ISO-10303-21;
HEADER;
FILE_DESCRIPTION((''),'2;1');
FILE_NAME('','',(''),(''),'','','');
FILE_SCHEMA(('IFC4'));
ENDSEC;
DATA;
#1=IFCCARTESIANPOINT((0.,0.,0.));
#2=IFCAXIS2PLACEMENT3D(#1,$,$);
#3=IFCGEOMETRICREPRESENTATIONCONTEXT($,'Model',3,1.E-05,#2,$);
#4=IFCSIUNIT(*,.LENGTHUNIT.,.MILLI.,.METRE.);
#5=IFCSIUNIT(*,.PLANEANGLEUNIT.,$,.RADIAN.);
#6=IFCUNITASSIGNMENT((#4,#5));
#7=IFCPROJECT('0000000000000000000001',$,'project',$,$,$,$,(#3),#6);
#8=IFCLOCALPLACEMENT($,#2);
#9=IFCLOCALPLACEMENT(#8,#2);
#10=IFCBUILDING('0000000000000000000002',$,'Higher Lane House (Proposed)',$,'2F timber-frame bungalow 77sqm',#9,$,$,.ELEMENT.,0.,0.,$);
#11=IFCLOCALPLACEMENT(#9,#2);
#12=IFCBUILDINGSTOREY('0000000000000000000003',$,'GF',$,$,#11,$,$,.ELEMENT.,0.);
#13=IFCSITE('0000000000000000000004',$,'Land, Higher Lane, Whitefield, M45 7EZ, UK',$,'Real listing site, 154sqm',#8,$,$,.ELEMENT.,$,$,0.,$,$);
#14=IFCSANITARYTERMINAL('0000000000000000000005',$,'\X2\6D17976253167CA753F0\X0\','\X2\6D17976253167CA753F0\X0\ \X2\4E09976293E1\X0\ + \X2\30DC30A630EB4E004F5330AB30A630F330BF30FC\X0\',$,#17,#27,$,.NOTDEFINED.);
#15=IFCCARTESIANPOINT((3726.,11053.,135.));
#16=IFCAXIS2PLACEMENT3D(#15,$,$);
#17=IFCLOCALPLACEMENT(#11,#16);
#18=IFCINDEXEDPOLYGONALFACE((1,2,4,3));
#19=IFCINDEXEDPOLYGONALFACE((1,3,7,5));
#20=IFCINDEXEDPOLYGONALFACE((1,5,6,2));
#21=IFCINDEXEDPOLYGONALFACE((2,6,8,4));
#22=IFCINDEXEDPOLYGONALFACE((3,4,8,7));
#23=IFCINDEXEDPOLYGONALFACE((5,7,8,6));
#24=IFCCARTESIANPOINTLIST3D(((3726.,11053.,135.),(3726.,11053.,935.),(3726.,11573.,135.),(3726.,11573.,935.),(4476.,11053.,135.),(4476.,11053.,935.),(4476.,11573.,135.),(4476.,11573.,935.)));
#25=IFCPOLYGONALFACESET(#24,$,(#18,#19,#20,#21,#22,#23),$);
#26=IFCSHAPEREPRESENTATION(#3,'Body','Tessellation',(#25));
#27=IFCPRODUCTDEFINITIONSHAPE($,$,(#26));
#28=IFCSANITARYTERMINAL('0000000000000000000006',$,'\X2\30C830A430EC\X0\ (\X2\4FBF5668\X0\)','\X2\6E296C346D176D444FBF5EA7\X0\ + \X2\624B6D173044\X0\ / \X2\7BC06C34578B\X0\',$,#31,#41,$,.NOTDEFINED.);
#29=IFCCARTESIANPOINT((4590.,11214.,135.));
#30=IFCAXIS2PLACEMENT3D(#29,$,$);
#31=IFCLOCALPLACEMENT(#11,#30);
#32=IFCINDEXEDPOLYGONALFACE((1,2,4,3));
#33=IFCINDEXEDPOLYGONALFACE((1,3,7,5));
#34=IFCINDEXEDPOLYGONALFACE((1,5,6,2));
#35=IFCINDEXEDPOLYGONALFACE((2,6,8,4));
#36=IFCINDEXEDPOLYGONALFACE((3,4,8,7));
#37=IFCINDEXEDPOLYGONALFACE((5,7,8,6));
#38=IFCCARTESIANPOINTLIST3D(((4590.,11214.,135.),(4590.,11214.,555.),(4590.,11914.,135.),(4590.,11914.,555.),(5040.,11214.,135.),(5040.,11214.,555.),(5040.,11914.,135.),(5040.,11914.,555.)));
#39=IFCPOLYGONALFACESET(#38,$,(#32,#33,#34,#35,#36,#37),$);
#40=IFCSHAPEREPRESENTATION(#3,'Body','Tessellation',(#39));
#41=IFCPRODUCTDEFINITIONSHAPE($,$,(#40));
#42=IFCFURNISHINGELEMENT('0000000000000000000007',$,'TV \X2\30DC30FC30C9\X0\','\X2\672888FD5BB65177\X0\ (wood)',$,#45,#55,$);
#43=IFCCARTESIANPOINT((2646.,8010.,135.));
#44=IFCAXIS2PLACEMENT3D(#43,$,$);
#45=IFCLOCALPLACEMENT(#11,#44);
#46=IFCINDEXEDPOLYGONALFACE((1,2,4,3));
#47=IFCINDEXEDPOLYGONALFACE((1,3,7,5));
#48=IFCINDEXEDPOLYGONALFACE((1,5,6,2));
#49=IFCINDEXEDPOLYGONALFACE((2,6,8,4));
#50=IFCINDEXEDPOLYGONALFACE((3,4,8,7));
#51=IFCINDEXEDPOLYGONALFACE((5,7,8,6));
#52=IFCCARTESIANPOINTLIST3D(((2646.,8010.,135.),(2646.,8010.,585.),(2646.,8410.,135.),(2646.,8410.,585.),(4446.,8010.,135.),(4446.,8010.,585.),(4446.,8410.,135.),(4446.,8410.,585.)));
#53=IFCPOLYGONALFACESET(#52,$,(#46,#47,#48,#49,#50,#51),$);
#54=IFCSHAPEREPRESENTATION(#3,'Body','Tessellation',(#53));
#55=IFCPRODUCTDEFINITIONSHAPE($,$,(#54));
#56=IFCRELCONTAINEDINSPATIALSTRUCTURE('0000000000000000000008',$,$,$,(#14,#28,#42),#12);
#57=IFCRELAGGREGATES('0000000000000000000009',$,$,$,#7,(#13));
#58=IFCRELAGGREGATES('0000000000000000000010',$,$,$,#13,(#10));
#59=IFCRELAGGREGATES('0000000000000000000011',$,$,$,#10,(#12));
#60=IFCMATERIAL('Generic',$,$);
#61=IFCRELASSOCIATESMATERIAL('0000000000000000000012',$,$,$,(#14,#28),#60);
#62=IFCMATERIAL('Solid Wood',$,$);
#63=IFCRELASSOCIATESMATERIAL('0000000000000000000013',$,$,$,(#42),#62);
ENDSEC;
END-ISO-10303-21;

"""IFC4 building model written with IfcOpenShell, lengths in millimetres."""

from ifc_helpers import new_model, si_unit, frame, frame_2d, origin, place, context, project, spatial, rectangle, extrude, material, element, save


model = new_model("IFC4")

# Units and contexts
model_context = context("Model", 3, precision=1e-05, world=origin())
ifc_project = project(units=[si_unit("LENGTHUNIT", "METRE", prefix="MILLI"), si_unit("PLANEANGLEUNIT", "RADIAN")], contexts=[model_context])

# Site, building, storey
site_placement = place(None, origin())
site = spatial("IfcSite", under=ifc_project, at=site_placement, Name="Land, Higher Lane, Whitefield, M45 7EZ, UK", ObjectType="Real listing site, 154sqm", CompositionType="ELEMENT", RefElevation=0.0)
building_placement = place(site_placement, origin())
building = spatial("IfcBuilding", under=site, at=building_placement, Name="Higher Lane House (Proposed)", ObjectType="2F timber-frame bungalow 77sqm", CompositionType="ELEMENT", ElevationOfRefHeight=0.0, ElevationOfTerrain=0.0)
storey_placement = place(building_placement, origin())
storey = spatial("IfcBuildingStorey", under=building, at=storey_placement, Name="GF", CompositionType="ELEMENT", Elevation=0.0)

# Shared definitions
ifc_material_1 = material(Name="Solid Wood")

# Shared definitions
ifc_material_2 = material(Name="Generic")

# Sanitary terminals
sanitary_terminal_1_placement = place(storey_placement, frame((3726.0, 11053.0, 135.0)))
element("IfcSanitaryTerminal", 1, at=sanitary_terminal_1_placement, inside=storey, material=ifc_material_2, Name="洗面化粧台", Description="洗面化粧台 三面鏡 + ボウル一体カウンター", PredefinedType="NOTDEFINED", context=model_context, shape_type="SweptSolid", body=[
    extrude(rectangle(XDim=750.0, YDim=520.0, at=frame_2d((375.0, 260.0))), frame((3726.0, 11053.0, 135.0)), (0.0, 0.0, 1.0), 800.0),
])
sanitary_terminal_2_placement = place(storey_placement, frame((4590.0, 11214.0, 135.0)))
element("IfcSanitaryTerminal", 2, at=sanitary_terminal_2_placement, inside=storey, material=ifc_material_2, Name="トイレ (便器)", Description="温水洗浄便座 + 手洗い / 節水型", PredefinedType="NOTDEFINED", context=model_context, shape_type="SweptSolid", body=[
    extrude(rectangle(XDim=450.0, YDim=700.0, at=frame_2d((225.0, 350.0))), frame((4590.0, 11214.0, 135.0)), (0.0, 0.0, 1.0), 420.0),
])

# Furnishing element
furnishing_placement = place(storey_placement, frame((2646.0, 8010.0, 135.0)))
element("IfcFurnishingElement", 3, at=furnishing_placement, inside=storey, material=ifc_material_1, Name="TV ボード", Description="木製家具 (wood)", context=model_context, shape_type="SweptSolid", body=[
    extrude(rectangle(XDim=1800.0, YDim=400.0, at=frame_2d((900.0, 200.0))), frame((2646.0, 8010.0, 135.0)), (0.0, 0.0, 1.0), 450.0),
])

save(model, "model.ifc")
